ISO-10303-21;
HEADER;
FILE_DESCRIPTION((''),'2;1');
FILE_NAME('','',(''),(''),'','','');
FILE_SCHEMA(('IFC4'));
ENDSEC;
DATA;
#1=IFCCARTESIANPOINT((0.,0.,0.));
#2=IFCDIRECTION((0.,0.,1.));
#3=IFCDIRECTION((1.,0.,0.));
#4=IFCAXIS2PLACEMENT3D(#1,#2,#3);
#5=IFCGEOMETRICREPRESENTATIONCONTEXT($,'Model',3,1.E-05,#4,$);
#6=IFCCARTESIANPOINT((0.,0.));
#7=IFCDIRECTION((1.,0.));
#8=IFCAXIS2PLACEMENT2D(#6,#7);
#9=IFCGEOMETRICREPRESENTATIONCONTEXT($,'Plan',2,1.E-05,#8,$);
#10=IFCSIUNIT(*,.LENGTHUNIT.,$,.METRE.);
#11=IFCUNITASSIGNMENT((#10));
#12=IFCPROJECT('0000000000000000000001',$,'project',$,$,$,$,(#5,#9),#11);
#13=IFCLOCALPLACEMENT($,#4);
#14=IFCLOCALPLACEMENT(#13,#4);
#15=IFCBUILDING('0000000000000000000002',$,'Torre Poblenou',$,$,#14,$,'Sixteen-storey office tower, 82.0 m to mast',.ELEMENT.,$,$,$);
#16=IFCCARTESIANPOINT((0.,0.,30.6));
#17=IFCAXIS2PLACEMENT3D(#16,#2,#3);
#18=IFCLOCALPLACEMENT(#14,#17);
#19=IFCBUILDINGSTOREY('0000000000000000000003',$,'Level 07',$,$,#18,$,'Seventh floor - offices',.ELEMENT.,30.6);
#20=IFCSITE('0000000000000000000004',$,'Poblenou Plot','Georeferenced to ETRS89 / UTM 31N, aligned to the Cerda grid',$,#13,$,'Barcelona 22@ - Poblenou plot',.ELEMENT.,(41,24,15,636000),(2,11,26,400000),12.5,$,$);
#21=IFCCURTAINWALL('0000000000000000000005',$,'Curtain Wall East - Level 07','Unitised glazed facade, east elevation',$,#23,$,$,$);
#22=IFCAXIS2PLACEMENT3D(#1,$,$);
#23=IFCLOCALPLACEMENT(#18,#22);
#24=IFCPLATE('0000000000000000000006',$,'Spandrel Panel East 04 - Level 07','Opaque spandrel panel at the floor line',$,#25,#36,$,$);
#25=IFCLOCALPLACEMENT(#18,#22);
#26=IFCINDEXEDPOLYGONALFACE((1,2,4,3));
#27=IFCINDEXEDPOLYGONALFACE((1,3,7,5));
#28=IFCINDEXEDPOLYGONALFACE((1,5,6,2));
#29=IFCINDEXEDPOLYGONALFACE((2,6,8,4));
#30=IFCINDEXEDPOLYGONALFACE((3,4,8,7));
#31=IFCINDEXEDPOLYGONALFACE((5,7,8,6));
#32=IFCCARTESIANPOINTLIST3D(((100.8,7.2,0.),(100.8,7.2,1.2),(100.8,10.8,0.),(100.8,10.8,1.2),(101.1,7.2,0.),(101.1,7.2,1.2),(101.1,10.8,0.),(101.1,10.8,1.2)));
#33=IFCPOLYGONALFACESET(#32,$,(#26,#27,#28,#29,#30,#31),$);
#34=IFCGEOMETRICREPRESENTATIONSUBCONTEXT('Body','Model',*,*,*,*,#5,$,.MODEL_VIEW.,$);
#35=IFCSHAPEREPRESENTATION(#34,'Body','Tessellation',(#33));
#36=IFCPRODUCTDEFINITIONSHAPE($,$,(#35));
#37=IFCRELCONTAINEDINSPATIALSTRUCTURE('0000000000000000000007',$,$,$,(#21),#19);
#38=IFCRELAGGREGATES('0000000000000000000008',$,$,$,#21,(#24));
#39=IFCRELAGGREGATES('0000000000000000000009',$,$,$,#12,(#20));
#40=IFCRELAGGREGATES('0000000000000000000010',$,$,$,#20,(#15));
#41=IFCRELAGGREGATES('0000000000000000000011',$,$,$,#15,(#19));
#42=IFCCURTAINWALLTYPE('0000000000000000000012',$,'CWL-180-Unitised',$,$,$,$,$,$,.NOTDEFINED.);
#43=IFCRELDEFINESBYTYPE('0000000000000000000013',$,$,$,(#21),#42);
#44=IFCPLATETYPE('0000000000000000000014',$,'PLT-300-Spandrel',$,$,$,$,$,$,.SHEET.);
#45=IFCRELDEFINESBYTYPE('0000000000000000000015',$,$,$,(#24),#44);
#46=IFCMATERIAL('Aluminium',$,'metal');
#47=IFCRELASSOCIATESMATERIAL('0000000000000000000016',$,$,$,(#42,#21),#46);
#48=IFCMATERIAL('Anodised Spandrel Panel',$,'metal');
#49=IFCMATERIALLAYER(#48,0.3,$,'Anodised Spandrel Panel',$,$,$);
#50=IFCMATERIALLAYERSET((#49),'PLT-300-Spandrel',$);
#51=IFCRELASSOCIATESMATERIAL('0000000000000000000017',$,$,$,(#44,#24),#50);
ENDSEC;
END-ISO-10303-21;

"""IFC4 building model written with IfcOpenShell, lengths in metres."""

from ifc_helpers import new_model, si_unit, frame, origin_with_axes, origin_2d_with_axis, place, context, subcontext, project, spatial, line, indexed_curve, outline, extrude, material, layer, layer_set, layer_usage, type_object, element, aggregate, save


model = new_model("IFC4")

# Units and contexts
model_context = context("Model", 3, precision=1e-05, world=origin_with_axes())
plan_context = context("Plan", 2, precision=1e-05, world=origin_2d_with_axis())
body_context = subcontext(model_context, "Body", "Model", "MODEL_VIEW")
ifc_project = project(units=[si_unit("LENGTHUNIT", "METRE")], contexts=[model_context, plan_context])

# Site, building, storey
site_placement = place(None, origin_with_axes())
site = spatial("IfcSite", under=ifc_project, at=site_placement, Name="Poblenou Plot", Description="Georeferenced to ETRS89 / UTM 31N, aligned to the Cerda grid", LongName="Barcelona 22@ - Poblenou plot", CompositionType="ELEMENT", RefLatitude=(41, 24, 15, 636000), RefLongitude=(2, 11, 26, 400000), RefElevation=12.5)
building_placement = place(site_placement, origin_with_axes())
building = spatial("IfcBuilding", under=site, at=building_placement, Name="Torre Poblenou", LongName="Sixteen-storey office tower, 82.0 m to mast", CompositionType="ELEMENT")
storey_placement = place(building_placement, frame((0.0, 0.0, 30.6), z_axis=(0.0, 0.0, 1.0), x_axis=(1.0, 0.0, 0.0)))
storey = spatial("IfcBuildingStorey", under=building, at=storey_placement, Name="Level 07", LongName="Seventh floor - offices", CompositionType="ELEMENT", Elevation=30.6)

# Curtain wall
ifc_material_1 = material(Name="Aluminium", Category="metal")
curtain_wall_type = type_object("IfcCurtainWallType", Name="CWL-180-Unitised", PredefinedType="NOTDEFINED", material=ifc_material_1)
curtain_wall_1_placement = place(storey_placement, frame((100.8, 21.6, 0.0), z_axis=(0.0, 0.0, 1.0), x_axis=(0.0, -1.0, 0.0)))
curtain_wall_1 = element("IfcCurtainWall", 1, at=curtain_wall_1_placement, inside=storey, type_object=curtain_wall_type, material=ifc_material_1, Name="Curtain Wall East - Level 07", Description="Unitised glazed facade, east elevation")

# Plate
ifc_material_2 = material(Name="Anodised Spandrel Panel", Category="metal")
ifc_layer_1 = layer(ifc_material_2, 0.3, Name="Anodised Spandrel Panel")
ifc_layer_set_1 = layer_set([ifc_layer_1], Name="PLT-300-Spandrel")
plate_type_1 = type_object("IfcPlateType", Name="PLT-300-Spandrel", PredefinedType="SHEET", material=ifc_layer_set_1)
ifc_layer_usage_1 = layer_usage(ifc_layer_set_1, "AXIS2", "POSITIVE", 0.0)
plate_1_placement = place(curtain_wall_1_placement, frame((10.8, 0.0, 0.0), z_axis=(0.0, 0.0, 1.0), x_axis=(1.0, 0.0, 0.0)))
plate_1 = element("IfcPlate", 2, at=plate_1_placement, type_object=plate_type_1, material=ifc_layer_usage_1, Name="Spandrel Panel East 04 - Level 07", Description="Opaque spandrel panel at the floor line", context=body_context, shape_type="SweptSolid", body=[
    extrude(outline(indexed_curve([(0.0, 0.0), (3.6, 0.0), (3.6, 0.3), (0.0, 0.3)], segments=[line(1, 2, 3, 4, 1)])), origin_with_axes(), (0.0, 0.0, 1.0), 1.2),
])
aggregate(curtain_wall_1, [plate_1])

save(model, "model.ifc")
